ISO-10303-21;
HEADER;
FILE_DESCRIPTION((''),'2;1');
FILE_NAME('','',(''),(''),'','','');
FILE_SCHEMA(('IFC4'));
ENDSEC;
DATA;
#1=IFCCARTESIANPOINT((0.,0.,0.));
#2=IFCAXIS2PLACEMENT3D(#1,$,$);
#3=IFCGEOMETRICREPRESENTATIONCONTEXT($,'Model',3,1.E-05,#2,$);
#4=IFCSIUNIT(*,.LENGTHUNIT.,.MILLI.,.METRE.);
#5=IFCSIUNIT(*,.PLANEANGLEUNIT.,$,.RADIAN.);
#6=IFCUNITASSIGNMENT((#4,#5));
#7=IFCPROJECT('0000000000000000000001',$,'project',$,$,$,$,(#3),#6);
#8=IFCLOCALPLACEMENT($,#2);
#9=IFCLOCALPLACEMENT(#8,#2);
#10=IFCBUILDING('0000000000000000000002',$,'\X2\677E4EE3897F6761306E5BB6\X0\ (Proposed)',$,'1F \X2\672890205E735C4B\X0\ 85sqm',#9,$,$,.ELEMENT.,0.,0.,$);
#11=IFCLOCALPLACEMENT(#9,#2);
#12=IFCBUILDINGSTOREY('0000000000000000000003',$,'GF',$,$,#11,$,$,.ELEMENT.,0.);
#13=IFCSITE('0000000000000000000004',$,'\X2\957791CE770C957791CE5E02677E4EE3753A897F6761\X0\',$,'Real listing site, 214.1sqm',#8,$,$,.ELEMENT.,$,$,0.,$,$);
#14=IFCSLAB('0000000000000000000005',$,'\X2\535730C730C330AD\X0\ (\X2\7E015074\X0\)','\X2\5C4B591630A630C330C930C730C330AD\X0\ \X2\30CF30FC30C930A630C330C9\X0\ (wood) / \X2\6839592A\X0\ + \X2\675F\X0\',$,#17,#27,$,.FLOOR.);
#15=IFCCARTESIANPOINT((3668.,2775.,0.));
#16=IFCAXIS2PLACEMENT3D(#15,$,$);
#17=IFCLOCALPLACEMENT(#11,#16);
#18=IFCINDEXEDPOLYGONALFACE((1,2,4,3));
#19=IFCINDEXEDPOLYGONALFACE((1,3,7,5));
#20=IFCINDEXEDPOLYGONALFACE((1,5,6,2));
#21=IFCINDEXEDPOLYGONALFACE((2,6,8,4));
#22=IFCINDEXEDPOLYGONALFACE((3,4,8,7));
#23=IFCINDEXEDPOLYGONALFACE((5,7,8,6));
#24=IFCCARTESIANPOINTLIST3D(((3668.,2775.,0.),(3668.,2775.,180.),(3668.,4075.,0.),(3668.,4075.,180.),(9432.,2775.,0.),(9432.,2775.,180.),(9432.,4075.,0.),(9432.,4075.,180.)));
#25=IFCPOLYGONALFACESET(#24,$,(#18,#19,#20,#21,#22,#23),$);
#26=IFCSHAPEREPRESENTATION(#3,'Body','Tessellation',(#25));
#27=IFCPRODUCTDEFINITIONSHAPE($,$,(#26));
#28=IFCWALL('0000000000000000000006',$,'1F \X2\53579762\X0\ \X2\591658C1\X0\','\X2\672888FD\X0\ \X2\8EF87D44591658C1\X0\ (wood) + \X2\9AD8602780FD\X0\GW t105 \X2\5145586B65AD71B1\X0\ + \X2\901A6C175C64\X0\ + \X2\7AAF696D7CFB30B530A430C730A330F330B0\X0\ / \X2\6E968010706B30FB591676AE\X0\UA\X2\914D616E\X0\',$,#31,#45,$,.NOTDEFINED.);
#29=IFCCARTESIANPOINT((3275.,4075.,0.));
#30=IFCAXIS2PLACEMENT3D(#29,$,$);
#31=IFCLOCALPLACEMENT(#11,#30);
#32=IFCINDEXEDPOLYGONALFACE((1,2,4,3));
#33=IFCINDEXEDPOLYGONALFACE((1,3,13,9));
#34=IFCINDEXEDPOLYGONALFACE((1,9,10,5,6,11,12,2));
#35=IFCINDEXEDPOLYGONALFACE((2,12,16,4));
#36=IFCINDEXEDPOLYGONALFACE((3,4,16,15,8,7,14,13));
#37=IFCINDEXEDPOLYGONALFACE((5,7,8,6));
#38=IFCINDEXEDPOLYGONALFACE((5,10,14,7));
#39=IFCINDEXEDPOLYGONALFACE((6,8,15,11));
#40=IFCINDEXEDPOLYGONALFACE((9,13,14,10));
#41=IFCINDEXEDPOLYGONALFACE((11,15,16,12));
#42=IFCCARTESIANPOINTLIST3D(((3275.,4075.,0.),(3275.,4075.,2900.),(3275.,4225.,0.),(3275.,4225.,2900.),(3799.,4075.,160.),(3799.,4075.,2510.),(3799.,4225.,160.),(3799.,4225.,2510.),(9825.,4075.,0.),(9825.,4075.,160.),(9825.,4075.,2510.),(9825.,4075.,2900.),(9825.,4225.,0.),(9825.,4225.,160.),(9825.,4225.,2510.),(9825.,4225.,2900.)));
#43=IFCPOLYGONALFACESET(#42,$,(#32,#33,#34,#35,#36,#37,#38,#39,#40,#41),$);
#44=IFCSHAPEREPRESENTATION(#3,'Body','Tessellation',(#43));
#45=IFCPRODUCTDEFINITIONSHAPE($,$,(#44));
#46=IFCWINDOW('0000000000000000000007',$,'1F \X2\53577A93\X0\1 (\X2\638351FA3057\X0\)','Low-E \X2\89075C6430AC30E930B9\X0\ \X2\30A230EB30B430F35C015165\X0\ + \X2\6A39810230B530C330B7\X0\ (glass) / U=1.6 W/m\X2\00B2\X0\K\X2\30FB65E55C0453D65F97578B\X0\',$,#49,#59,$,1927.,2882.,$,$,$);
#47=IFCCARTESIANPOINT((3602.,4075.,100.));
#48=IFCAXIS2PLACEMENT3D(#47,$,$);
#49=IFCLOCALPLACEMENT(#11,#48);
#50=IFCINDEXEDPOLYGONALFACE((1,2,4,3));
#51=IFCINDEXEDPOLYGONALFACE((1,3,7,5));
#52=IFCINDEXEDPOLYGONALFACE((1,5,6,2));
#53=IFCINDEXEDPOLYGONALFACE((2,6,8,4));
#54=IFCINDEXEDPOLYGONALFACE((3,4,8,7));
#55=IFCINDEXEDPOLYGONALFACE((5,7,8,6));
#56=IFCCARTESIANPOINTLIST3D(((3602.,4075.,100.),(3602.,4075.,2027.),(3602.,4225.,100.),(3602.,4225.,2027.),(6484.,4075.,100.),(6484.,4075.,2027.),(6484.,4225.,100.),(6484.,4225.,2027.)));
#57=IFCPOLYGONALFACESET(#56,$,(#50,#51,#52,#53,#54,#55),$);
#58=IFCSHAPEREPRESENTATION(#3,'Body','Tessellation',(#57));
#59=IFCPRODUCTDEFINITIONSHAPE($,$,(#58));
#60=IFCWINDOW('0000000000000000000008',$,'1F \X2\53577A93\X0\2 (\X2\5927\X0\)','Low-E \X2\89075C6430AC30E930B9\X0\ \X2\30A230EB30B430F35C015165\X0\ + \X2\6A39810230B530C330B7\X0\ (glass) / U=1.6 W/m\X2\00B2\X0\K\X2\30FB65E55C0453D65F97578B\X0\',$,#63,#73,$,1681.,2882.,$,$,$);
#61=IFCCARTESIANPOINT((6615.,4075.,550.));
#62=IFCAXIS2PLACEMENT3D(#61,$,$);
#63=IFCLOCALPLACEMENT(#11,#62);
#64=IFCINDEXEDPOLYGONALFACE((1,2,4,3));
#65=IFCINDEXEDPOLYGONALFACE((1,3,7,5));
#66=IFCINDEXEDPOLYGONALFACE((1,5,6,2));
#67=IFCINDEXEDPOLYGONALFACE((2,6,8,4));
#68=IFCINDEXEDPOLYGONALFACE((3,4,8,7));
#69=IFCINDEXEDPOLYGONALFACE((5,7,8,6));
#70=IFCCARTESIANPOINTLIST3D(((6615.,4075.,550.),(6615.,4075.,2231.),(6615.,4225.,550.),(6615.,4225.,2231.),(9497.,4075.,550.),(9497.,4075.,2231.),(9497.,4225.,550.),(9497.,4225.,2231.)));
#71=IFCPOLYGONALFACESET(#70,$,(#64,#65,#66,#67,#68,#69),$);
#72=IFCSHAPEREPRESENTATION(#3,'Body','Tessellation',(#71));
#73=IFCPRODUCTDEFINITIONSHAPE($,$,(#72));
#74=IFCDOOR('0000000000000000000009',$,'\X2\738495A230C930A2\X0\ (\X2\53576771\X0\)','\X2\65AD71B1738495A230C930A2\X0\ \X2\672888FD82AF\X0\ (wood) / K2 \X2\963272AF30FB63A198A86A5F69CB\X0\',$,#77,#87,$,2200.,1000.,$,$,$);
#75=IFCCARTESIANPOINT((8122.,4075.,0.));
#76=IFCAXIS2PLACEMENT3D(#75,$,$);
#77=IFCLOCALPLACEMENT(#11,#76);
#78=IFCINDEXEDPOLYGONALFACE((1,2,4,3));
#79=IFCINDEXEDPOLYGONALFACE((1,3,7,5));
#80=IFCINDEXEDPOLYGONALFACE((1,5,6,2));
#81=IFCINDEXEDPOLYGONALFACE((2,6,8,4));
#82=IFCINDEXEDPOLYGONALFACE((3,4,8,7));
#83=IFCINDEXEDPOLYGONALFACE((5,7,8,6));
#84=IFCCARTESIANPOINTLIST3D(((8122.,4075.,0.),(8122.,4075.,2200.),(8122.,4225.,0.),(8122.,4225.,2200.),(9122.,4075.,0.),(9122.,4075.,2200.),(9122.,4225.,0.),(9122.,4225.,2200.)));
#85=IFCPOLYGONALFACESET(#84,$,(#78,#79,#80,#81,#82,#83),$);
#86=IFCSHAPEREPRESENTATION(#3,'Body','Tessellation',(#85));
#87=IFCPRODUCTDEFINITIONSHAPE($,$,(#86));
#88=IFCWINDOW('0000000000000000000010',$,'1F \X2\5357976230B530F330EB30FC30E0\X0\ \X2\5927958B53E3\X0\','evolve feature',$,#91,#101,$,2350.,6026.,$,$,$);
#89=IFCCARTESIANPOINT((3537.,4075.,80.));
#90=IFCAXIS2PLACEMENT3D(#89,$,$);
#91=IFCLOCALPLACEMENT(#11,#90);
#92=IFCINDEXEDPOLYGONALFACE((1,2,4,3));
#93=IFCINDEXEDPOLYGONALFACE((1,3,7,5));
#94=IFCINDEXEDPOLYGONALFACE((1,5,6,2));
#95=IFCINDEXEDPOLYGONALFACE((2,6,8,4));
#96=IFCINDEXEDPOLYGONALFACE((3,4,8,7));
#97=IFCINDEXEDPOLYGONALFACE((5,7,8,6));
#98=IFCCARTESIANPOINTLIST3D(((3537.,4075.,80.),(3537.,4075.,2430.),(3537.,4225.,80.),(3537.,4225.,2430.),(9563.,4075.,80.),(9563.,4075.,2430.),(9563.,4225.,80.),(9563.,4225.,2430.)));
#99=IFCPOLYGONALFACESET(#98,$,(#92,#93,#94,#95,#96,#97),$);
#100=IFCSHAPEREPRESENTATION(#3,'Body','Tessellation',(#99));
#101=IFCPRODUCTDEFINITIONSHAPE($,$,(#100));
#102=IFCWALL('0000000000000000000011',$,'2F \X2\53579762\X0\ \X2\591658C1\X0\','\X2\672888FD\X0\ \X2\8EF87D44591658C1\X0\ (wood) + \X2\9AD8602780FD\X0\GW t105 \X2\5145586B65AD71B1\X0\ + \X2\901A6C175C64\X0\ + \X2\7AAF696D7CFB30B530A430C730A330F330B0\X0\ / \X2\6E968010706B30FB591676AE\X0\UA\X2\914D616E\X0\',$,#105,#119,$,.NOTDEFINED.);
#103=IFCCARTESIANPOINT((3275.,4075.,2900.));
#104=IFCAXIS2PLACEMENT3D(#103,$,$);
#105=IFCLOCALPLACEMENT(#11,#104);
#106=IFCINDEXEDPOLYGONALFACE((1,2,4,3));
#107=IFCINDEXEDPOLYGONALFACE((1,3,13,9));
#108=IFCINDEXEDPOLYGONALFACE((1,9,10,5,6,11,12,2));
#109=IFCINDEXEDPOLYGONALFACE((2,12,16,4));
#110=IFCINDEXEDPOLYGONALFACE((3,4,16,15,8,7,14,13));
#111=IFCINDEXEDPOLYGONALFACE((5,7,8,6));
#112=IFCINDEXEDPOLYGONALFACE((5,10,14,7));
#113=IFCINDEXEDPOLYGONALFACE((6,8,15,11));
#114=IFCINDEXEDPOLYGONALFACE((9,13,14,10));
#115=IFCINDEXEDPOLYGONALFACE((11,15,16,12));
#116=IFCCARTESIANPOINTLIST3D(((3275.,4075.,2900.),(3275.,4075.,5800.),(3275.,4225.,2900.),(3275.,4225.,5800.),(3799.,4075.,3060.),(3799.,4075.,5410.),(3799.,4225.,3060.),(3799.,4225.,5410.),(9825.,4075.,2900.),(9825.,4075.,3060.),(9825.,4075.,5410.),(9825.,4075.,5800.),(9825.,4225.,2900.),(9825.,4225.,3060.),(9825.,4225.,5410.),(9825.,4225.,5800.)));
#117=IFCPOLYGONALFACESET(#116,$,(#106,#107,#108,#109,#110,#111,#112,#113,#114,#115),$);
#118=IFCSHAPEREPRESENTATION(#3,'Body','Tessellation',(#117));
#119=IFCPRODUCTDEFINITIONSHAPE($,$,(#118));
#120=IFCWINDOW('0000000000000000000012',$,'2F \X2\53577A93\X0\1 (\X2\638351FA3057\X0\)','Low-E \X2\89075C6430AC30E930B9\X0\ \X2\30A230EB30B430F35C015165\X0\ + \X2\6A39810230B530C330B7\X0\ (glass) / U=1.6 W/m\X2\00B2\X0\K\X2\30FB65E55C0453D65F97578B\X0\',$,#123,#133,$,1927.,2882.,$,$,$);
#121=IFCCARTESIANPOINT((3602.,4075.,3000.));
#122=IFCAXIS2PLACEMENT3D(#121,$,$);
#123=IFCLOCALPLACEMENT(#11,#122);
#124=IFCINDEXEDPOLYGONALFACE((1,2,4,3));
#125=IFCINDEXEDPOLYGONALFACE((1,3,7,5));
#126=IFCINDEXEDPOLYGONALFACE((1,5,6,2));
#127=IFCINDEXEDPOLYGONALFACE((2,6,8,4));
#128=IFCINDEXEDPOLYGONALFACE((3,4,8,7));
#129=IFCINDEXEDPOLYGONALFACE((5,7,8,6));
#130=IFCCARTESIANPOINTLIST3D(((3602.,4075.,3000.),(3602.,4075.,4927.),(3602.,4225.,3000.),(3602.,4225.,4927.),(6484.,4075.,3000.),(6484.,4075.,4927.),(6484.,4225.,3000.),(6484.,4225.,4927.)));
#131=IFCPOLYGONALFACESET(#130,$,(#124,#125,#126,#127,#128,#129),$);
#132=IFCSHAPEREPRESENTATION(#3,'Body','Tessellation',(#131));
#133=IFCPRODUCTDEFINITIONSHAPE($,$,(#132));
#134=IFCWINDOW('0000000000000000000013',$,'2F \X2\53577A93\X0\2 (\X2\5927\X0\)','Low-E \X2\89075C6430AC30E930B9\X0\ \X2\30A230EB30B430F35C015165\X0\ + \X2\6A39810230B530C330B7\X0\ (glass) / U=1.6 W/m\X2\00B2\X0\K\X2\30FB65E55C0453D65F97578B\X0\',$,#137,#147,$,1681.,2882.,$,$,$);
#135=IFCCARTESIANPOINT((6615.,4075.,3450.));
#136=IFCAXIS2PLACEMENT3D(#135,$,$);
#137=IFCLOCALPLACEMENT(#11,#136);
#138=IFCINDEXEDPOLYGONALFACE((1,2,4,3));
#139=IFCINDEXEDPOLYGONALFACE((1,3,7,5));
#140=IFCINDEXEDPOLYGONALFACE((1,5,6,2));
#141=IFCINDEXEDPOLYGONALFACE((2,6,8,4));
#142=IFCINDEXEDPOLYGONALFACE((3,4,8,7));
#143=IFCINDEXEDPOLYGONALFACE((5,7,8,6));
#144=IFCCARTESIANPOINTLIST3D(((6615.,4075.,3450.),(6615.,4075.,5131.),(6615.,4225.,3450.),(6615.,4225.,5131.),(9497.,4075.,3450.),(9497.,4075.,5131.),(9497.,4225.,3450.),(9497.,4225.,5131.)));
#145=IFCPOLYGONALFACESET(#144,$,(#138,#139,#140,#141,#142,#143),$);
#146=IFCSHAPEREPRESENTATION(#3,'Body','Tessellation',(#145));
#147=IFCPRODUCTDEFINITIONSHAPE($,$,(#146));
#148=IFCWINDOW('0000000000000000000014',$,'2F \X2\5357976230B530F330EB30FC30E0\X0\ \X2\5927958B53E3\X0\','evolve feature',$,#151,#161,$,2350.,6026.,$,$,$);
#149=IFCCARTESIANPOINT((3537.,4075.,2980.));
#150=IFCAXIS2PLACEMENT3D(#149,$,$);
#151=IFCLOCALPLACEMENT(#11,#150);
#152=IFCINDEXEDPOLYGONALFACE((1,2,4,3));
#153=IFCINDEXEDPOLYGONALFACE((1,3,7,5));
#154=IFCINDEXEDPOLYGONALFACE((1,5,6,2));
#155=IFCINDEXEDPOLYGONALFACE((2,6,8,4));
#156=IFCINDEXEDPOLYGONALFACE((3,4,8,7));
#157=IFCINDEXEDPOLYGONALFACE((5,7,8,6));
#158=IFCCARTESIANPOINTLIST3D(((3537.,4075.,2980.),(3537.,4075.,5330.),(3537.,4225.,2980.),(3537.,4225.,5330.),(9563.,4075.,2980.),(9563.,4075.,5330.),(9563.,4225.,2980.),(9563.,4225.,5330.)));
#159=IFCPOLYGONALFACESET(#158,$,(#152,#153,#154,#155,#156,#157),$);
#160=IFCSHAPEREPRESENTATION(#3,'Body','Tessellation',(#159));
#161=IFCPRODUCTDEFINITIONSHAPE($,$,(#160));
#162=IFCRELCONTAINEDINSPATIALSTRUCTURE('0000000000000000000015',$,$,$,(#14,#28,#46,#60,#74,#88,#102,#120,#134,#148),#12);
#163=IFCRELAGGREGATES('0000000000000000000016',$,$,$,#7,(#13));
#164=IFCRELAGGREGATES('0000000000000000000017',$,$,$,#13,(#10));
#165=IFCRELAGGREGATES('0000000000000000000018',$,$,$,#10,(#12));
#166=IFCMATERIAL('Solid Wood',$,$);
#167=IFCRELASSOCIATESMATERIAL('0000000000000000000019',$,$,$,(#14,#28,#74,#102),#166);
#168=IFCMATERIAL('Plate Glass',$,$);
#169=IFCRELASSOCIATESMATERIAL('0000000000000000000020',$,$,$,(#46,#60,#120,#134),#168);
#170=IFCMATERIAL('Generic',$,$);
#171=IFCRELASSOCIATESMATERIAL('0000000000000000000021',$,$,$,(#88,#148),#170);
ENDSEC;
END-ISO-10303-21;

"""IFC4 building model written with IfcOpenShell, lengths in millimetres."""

from ifc_helpers import new_model, si_unit, frame, frame_2d, origin, place, context, project, spatial, rectangle, extrude, material, element, fill, save


model = new_model("IFC4")

# Units and contexts
model_context = context("Model", 3, precision=1e-05, world=origin())
ifc_project = project(units=[si_unit("LENGTHUNIT", "METRE", prefix="MILLI"), si_unit("PLANEANGLEUNIT", "RADIAN")], contexts=[model_context])

# Site, building, storey
site_placement = place(None, origin())
site = spatial("IfcSite", under=ifc_project, at=site_placement, Name="長野県長野市松代町西条", ObjectType="Real listing site, 214.1sqm", CompositionType="ELEMENT", RefElevation=0.0)
building_placement = place(site_placement, origin())
building = spatial("IfcBuilding", under=site, at=building_placement, Name="松代西条の家 (Proposed)", ObjectType="1F 木造平屋 85sqm", CompositionType="ELEMENT", ElevationOfRefHeight=0.0, ElevationOfTerrain=0.0)
storey_placement = place(building_placement, origin())
storey = spatial("IfcBuildingStorey", under=building, at=storey_placement, Name="GF", CompositionType="ELEMENT", Elevation=0.0)

# Slab
ifc_material_1 = material(Name="Solid Wood")
slab_1_placement = place(storey_placement, frame((3668.0, 2775.0, 0.0)))
element("IfcSlab", 1, at=slab_1_placement, inside=storey, material=ifc_material_1, Name="南デッキ (縁側)", Description="屋外ウッドデッキ ハードウッド (wood) / 根太 + 束", PredefinedType="FLOOR", context=model_context, shape_type="SweptSolid", body=[
    extrude(rectangle(XDim=5764.0, YDim=1300.0, at=frame_2d((2882.0, 650.0))), frame((3668.0, 2775.0, 0.0)), (0.0, 0.0, 1.0), 180.0),
])
ifc_material_2 = material(Name="Generic")

# Wall, openings, windows, door
wall_1_placement = place(storey_placement, frame((3275.0, 4075.0, 0.0)))
wall_1 = element("IfcWall", 2, at=wall_1_placement, inside=storey, material=ifc_material_1, Name="1F 南面 外壁", Description="木製 軸組外壁 (wood) + 高性能GW t105 充填断熱 + 通気層 + 窯業系サイディング / 準耐火・外皮UA配慮", PredefinedType="NOTDEFINED", context=model_context, shape_type="SweptSolid", body=[
    extrude(rectangle(XDim=6550.0, YDim=150.0, at=frame_2d((3275.0, 75.0))), frame((3275.0, 4075.0, 0.0)), (0.0, 0.0, 1.0), 2900.0),
])
opening_1_placement = place(storey_placement, frame((3602.0, 4075.0, 100.0)))
opening_1 = element("IfcOpeningElement", 3, at=opening_1_placement, cuts=wall_1, PredefinedType="NOTDEFINED", context=model_context, shape_type="SweptSolid", body=[
    extrude(rectangle(XDim=2882.0, YDim=150.0, at=frame_2d((1441.0, 75.0))), frame((3602.0, 4075.0, 100.0)), (0.0, 0.0, 1.0), 1927.0),
])
opening_2_placement = place(storey_placement, frame((6615.0, 4075.0, 550.0)))
opening_2 = element("IfcOpeningElement", 4, at=opening_2_placement, cuts=wall_1, PredefinedType="NOTDEFINED", context=model_context, shape_type="SweptSolid", body=[
    extrude(rectangle(XDim=2882.0, YDim=150.0, at=frame_2d((1441.0, 75.0))), frame((6615.0, 4075.0, 550.0)), (0.0, 0.0, 1.0), 1681.0),
])
opening_3_placement = place(storey_placement, frame((8122.0, 4075.0, 0.0)))
opening_3 = element("IfcOpeningElement", 5, at=opening_3_placement, cuts=wall_1, PredefinedType="NOTDEFINED", context=model_context, shape_type="SweptSolid", body=[
    extrude(rectangle(XDim=1000.0, YDim=150.0, at=frame_2d((500.0, 75.0))), frame((8122.0, 4075.0, 0.0)), (0.0, 0.0, 1.0), 2200.0),
])
opening_4_placement = place(storey_placement, frame((3537.0, 4075.0, 80.0)))
opening_4 = element("IfcOpeningElement", 6, at=opening_4_placement, cuts=wall_1, PredefinedType="NOTDEFINED", context=model_context, shape_type="SweptSolid", body=[
    extrude(rectangle(XDim=6026.0, YDim=150.0, at=frame_2d((3013.0, 75.0))), frame((3537.0, 4075.0, 80.0)), (0.0, 0.0, 1.0), 2350.0),
])
ifc_material_3 = material(Name="Plate Glass")
window_1_placement = place(storey_placement, frame((3602.0, 4075.0, 100.0)))
window_1 = element("IfcWindow", 7, at=window_1_placement, inside=storey, material=ifc_material_3, Name="1F 南窓1 (掃出し)", Description="Low-E 複層ガラス アルゴン封入 + 樹脂サッシ (glass) / U=1.6 W/m²K・日射取得型", OverallHeight=1927.0, OverallWidth=2882.0, context=model_context, shape_type="SweptSolid", body=[
    extrude(rectangle(XDim=2882.0, YDim=150.0, at=frame_2d((1441.0, 75.0))), frame((3602.0, 4075.0, 100.0)), (0.0, 0.0, 1.0), 1927.0),
])
fill(opening_1, window_1)
window_2_placement = place(storey_placement, frame((6615.0, 4075.0, 550.0)))
window_2 = element("IfcWindow", 8, at=window_2_placement, inside=storey, material=ifc_material_3, Name="1F 南窓2 (大)", Description="Low-E 複層ガラス アルゴン封入 + 樹脂サッシ (glass) / U=1.6 W/m²K・日射取得型", OverallHeight=1681.0, OverallWidth=2882.0, context=model_context, shape_type="SweptSolid", body=[
    extrude(rectangle(XDim=2882.0, YDim=150.0, at=frame_2d((1441.0, 75.0))), frame((6615.0, 4075.0, 550.0)), (0.0, 0.0, 1.0), 1681.0),
])
fill(opening_2, window_2)
door_placement = place(storey_placement, frame((8122.0, 4075.0, 0.0)))
door = element("IfcDoor", 9, at=door_placement, inside=storey, material=ifc_material_1, Name="玄関ドア (南東)", Description="断熱玄関ドア 木製芯 (wood) / K2 防犯・採風機構", OverallHeight=2200.0, OverallWidth=1000.0, context=model_context, shape_type="SweptSolid", body=[
    extrude(rectangle(XDim=1000.0, YDim=150.0, at=frame_2d((500.0, 75.0))), frame((8122.0, 4075.0, 0.0)), (0.0, 0.0, 1.0), 2200.0),
])
fill(opening_3, door)
window_3_placement = place(storey_placement, frame((3537.0, 4075.0, 80.0)))
window_3 = element("IfcWindow", 10, at=window_3_placement, inside=storey, material=ifc_material_2, Name="1F 南面サンルーム 大開口", Description="evolve feature", OverallHeight=2350.0, OverallWidth=6026.0, context=model_context, shape_type="SweptSolid", body=[
    extrude(rectangle(XDim=6026.0, YDim=150.0, at=frame_2d((3013.0, 75.0))), frame((3537.0, 4075.0, 80.0)), (0.0, 0.0, 1.0), 2350.0),
])
fill(opening_4, window_3)

# Wall, openings, windows
wall_2_placement = place(storey_placement, frame((3275.0, 4075.0, 2900.0)))
wall_2 = element("IfcWall", 11, at=wall_2_placement, inside=storey, material=ifc_material_1, Name="2F 南面 外壁", Description="木製 軸組外壁 (wood) + 高性能GW t105 充填断熱 + 通気層 + 窯業系サイディング / 準耐火・外皮UA配慮", PredefinedType="NOTDEFINED", context=model_context, shape_type="SweptSolid", body=[
    extrude(rectangle(XDim=6550.0, YDim=150.0, at=frame_2d((3275.0, 75.0))), frame((3275.0, 4075.0, 2900.0)), (0.0, 0.0, 1.0), 2900.0),
])
opening_5_placement = place(storey_placement, frame((3602.0, 4075.0, 3000.0)))
opening_5 = element("IfcOpeningElement", 12, at=opening_5_placement, cuts=wall_2, PredefinedType="NOTDEFINED", context=model_context, shape_type="SweptSolid", body=[
    extrude(rectangle(XDim=2882.0, YDim=150.0, at=frame_2d((1441.0, 75.0))), frame((3602.0, 4075.0, 3000.0)), (0.0, 0.0, 1.0), 1927.0),
])
opening_6_placement = place(storey_placement, frame((6615.0, 4075.0, 3450.0)))
opening_6 = element("IfcOpeningElement", 13, at=opening_6_placement, cuts=wall_2, PredefinedType="NOTDEFINED", context=model_context, shape_type="SweptSolid", body=[
    extrude(rectangle(XDim=2882.0, YDim=150.0, at=frame_2d((1441.0, 75.0))), frame((6615.0, 4075.0, 3450.0)), (0.0, 0.0, 1.0), 1681.0),
])
opening_7_placement = place(storey_placement, frame((3537.0, 4075.0, 2980.0)))
opening_7 = element("IfcOpeningElement", 14, at=opening_7_placement, cuts=wall_2, PredefinedType="NOTDEFINED", context=model_context, shape_type="SweptSolid", body=[
    extrude(rectangle(XDim=6026.0, YDim=150.0, at=frame_2d((3013.0, 75.0))), frame((3537.0, 4075.0, 2980.0)), (0.0, 0.0, 1.0), 2350.0),
])
window_4_placement = place(storey_placement, frame((3602.0, 4075.0, 3000.0)))
window_4 = element("IfcWindow", 15, at=window_4_placement, inside=storey, material=ifc_material_3, Name="2F 南窓1 (掃出し)", Description="Low-E 複層ガラス アルゴン封入 + 樹脂サッシ (glass) / U=1.6 W/m²K・日射取得型", OverallHeight=1927.0, OverallWidth=2882.0, context=model_context, shape_type="SweptSolid", body=[
    extrude(rectangle(XDim=2882.0, YDim=150.0, at=frame_2d((1441.0, 75.0))), frame((3602.0, 4075.0, 3000.0)), (0.0, 0.0, 1.0), 1927.0),
])
fill(opening_5, window_4)
window_5_placement = place(storey_placement, frame((6615.0, 4075.0, 3450.0)))
window_5 = element("IfcWindow", 16, at=window_5_placement, inside=storey, material=ifc_material_3, Name="2F 南窓2 (大)", Description="Low-E 複層ガラス アルゴン封入 + 樹脂サッシ (glass) / U=1.6 W/m²K・日射取得型", OverallHeight=1681.0, OverallWidth=2882.0, context=model_context, shape_type="SweptSolid", body=[
    extrude(rectangle(XDim=2882.0, YDim=150.0, at=frame_2d((1441.0, 75.0))), frame((6615.0, 4075.0, 3450.0)), (0.0, 0.0, 1.0), 1681.0),
])
fill(opening_6, window_5)
window_6_placement = place(storey_placement, frame((3537.0, 4075.0, 2980.0)))
window_6 = element("IfcWindow", 17, at=window_6_placement, inside=storey, material=ifc_material_2, Name="2F 南面サンルーム 大開口", Description="evolve feature", OverallHeight=2350.0, OverallWidth=6026.0, context=model_context, shape_type="SweptSolid", body=[
    extrude(rectangle(XDim=6026.0, YDim=150.0, at=frame_2d((3013.0, 75.0))), frame((3537.0, 4075.0, 2980.0)), (0.0, 0.0, 1.0), 2350.0),
])
fill(opening_7, window_6)

save(model, "model.ifc")
